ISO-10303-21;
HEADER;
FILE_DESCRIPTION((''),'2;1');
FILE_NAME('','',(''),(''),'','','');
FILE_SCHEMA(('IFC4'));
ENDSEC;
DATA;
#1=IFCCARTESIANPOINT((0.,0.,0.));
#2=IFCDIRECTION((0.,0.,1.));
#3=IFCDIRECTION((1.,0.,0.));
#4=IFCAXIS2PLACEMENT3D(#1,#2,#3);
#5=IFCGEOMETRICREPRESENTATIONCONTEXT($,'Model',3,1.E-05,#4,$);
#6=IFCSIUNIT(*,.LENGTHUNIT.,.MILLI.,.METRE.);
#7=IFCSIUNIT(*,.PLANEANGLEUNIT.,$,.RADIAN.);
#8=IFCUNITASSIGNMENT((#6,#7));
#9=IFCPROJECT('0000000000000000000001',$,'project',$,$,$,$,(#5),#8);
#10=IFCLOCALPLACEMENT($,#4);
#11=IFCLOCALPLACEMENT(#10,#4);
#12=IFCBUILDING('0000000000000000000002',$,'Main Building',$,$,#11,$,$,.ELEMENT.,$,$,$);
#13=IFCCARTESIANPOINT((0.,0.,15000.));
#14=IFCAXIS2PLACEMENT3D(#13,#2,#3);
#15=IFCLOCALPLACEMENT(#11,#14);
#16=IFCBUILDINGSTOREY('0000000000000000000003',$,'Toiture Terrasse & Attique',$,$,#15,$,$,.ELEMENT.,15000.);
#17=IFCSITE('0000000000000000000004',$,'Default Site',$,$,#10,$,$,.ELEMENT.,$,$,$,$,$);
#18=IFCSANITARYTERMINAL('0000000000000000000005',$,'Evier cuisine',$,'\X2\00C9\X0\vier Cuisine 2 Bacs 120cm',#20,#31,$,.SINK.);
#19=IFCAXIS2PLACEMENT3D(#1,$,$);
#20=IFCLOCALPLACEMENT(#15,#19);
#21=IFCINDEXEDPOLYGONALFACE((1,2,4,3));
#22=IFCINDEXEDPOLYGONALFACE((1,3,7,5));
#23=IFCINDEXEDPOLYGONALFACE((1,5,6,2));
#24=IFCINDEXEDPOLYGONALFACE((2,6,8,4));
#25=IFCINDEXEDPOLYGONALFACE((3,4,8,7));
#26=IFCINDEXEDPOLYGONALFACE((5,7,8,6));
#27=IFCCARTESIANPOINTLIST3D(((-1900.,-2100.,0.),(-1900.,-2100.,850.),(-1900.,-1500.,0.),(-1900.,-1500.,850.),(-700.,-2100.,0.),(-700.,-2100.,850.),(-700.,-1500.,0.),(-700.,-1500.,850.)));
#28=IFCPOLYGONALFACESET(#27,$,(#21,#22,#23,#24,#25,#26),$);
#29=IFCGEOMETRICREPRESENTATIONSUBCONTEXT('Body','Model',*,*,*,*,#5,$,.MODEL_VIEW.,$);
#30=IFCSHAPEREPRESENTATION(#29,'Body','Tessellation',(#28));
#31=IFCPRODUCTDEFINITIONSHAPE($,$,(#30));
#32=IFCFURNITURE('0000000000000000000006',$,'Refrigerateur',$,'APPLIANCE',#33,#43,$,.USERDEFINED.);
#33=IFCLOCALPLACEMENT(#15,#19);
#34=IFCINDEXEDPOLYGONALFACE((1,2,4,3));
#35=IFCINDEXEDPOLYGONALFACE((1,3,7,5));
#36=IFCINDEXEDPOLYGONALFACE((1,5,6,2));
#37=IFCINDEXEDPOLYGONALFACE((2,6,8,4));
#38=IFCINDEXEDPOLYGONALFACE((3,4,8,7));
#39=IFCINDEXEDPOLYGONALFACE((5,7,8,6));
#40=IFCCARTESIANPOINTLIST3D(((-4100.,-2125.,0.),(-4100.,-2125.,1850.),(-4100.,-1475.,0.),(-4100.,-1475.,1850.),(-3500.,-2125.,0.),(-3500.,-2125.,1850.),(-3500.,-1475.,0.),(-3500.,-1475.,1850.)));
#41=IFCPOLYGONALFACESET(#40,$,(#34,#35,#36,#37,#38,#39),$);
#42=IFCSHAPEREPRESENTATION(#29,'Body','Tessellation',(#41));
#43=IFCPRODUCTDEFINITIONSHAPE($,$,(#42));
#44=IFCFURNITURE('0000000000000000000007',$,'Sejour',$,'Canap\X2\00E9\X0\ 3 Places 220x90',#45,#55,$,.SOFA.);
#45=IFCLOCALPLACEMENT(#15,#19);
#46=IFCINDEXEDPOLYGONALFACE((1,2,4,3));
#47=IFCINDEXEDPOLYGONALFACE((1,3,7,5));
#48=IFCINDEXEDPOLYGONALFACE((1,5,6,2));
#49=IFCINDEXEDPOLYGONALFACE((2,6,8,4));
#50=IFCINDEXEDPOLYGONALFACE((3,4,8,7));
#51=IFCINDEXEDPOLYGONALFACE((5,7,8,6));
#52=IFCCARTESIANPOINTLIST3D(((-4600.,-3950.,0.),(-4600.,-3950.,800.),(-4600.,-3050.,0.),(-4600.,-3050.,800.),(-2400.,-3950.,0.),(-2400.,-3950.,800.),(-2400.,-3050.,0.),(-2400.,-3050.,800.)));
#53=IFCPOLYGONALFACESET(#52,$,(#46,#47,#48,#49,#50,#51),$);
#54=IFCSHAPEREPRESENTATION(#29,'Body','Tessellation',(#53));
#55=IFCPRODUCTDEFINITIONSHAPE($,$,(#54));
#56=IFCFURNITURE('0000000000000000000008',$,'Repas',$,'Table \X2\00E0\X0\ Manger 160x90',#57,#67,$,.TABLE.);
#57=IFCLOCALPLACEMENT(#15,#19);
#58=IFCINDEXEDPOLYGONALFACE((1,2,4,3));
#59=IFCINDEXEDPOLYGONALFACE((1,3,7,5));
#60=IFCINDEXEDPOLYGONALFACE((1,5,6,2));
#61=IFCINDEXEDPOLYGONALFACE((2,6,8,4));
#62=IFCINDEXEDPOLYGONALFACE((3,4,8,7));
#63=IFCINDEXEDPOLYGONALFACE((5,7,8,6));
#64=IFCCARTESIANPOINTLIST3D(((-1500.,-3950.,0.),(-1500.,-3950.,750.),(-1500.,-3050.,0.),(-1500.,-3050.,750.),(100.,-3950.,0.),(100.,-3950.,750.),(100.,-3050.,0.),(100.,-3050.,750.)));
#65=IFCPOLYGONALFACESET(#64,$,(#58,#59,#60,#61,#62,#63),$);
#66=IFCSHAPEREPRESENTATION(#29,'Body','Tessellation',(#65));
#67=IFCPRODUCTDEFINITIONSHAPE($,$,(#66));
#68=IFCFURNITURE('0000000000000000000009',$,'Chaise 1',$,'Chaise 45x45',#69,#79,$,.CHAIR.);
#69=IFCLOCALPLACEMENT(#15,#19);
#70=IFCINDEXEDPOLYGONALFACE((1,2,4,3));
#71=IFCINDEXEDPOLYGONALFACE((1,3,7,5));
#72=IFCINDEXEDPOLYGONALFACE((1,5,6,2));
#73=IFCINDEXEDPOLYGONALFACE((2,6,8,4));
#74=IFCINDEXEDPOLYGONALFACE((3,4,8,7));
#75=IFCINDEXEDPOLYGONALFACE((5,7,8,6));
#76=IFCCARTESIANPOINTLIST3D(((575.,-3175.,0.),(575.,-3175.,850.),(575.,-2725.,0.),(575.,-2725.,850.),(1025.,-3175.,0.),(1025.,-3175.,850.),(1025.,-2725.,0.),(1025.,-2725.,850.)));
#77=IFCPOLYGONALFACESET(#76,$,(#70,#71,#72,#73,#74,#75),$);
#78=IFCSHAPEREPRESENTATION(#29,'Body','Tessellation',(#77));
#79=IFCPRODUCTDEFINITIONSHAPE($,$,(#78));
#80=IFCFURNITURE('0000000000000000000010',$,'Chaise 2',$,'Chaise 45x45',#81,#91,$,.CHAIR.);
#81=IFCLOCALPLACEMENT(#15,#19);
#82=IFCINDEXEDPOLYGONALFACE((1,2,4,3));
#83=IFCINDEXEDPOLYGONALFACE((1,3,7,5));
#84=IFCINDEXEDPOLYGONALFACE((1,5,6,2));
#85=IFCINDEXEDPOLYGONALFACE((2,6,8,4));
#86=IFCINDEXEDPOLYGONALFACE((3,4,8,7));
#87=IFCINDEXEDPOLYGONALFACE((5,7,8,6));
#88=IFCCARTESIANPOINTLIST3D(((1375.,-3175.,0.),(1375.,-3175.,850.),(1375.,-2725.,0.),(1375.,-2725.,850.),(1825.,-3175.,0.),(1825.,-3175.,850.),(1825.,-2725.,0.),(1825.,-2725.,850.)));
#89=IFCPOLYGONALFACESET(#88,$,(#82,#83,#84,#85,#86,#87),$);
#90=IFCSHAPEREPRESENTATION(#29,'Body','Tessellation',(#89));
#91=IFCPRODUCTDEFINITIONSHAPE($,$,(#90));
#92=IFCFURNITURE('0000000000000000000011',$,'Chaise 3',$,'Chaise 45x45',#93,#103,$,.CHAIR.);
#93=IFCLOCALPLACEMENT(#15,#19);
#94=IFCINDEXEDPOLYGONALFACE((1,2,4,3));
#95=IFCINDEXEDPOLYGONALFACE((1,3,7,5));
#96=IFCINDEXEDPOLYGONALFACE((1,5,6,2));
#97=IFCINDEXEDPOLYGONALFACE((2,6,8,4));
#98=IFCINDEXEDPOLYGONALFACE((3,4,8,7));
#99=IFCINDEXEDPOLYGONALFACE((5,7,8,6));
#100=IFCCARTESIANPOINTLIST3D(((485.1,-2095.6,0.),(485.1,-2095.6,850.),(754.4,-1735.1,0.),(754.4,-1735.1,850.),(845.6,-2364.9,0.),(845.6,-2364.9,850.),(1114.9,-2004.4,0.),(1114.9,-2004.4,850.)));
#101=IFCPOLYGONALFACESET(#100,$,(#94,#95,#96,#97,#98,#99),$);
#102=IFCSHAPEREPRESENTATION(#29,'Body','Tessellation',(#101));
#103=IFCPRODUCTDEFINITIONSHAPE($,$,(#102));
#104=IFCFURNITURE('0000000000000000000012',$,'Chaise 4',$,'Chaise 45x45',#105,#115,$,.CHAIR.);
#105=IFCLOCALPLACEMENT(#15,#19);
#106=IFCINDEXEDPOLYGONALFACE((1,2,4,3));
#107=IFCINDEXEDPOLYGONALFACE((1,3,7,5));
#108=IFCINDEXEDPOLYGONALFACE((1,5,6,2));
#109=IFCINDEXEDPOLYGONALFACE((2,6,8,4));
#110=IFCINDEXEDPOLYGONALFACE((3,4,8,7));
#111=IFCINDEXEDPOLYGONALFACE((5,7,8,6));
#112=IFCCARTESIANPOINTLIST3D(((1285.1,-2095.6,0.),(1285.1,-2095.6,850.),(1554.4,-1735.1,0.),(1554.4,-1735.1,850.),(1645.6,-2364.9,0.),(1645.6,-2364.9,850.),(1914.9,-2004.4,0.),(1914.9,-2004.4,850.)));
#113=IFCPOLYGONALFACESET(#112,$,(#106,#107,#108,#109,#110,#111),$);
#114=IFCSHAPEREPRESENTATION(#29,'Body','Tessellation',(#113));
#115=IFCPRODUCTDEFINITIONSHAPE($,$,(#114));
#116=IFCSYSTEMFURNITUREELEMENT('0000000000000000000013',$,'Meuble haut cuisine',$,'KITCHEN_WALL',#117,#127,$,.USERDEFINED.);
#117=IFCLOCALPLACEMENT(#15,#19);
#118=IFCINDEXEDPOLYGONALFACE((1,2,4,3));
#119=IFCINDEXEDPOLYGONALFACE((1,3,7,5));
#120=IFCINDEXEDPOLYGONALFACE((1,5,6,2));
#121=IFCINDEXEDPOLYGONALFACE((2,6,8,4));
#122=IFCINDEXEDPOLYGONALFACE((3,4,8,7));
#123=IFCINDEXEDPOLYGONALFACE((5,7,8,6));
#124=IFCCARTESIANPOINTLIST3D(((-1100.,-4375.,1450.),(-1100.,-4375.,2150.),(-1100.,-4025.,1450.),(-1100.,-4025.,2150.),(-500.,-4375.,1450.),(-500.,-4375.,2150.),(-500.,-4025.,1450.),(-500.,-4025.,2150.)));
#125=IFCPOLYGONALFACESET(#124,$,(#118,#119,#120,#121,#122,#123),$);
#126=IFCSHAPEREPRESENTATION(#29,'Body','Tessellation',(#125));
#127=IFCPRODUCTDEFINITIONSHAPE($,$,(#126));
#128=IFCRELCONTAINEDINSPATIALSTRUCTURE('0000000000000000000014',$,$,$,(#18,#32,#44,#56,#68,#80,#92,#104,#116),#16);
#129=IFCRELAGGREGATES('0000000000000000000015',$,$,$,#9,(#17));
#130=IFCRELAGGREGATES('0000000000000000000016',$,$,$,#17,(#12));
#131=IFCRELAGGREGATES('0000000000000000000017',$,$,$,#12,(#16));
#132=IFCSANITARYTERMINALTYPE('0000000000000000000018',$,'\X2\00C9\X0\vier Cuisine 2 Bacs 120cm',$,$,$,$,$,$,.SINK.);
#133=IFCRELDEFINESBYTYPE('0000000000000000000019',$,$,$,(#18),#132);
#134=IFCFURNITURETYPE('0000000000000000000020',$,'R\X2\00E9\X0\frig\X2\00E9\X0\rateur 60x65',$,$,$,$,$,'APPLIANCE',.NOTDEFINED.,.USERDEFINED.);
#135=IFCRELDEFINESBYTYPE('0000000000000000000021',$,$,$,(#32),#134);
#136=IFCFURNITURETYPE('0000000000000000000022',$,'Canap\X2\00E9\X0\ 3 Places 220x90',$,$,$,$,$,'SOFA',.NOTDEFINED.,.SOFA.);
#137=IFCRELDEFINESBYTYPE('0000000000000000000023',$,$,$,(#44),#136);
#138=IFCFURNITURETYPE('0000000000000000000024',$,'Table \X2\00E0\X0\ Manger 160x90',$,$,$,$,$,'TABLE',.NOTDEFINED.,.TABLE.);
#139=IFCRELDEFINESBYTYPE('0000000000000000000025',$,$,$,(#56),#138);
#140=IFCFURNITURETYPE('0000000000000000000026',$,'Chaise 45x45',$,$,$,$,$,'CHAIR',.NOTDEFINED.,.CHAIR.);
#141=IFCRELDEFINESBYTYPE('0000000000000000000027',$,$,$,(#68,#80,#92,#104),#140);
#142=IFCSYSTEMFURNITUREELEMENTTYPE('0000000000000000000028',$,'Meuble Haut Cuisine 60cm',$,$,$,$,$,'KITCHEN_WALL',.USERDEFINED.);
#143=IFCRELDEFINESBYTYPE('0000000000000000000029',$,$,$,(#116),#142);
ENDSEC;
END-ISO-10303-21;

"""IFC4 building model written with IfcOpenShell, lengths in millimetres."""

from ifc_helpers import new_model, si_unit, frame, origin_with_axes, place, context, subcontext, project, spatial, polyline, outline, extrude, type_object, element, save


model = new_model("IFC4")

# Units and contexts
model_context = context("Model", 3, precision=1e-05, world=origin_with_axes())
body_context = subcontext(model_context, "Body", "Model", "MODEL_VIEW")
ifc_project = project(units=[si_unit("LENGTHUNIT", "METRE", prefix="MILLI"), si_unit("PLANEANGLEUNIT", "RADIAN")], contexts=[model_context])

# Site, building, storey
site_placement = place(None, origin_with_axes())
site = spatial("IfcSite", under=ifc_project, at=site_placement, Name="Default Site", CompositionType="ELEMENT")
building_placement = place(site_placement, origin_with_axes())
building = spatial("IfcBuilding", under=site, at=building_placement, Name="Main Building", CompositionType="ELEMENT")
storey_placement = place(building_placement, frame((0.0, 0.0, 15000.0), z_axis=(0.0, 0.0, 1.0), x_axis=(1.0, 0.0, 0.0)))
storey = spatial("IfcBuildingStorey", under=building, at=storey_placement, Name="Toiture Terrasse & Attique", CompositionType="ELEMENT", Elevation=15000.0)

# Sanitary terminal
sanitary_terminal_type = type_object("IfcSanitaryTerminalType", Name="Évier Cuisine 2 Bacs 120cm", PredefinedType="SINK")
sanitary_terminal_placement = place(storey_placement, frame((-1300.0, -1800.0, 0.0), z_axis=(0.0, 0.0, 1.0), x_axis=(1.0, 0.0, 0.0)))
element("IfcSanitaryTerminal", 1, at=sanitary_terminal_placement, inside=storey, type_object=sanitary_terminal_type, Name="Evier cuisine", ObjectType="Évier Cuisine 2 Bacs 120cm", PredefinedType="SINK", context=body_context, shape_type="SweptSolid", body=[
    extrude(outline(polyline([(-600.0, -300.0), (600.0, -300.0), (600.0, 300.0), (-600.0, 300.0), (-600.0, -300.0)])), origin_with_axes(), (0.0, 0.0, 1.0), 850.0),
])

# Furniture
furniture_type_1 = type_object("IfcFurnitureType", Name="Réfrigérateur 60x65", ElementType="APPLIANCE", AssemblyPlace="NOTDEFINED", PredefinedType="USERDEFINED")
furniture_1_placement = place(storey_placement, frame((-3800.0, -1800.0, 0.0), z_axis=(0.0, 0.0, 1.0), x_axis=(1.0, 0.0, 0.0)))
element("IfcFurniture", 2, at=furniture_1_placement, inside=storey, type_object=furniture_type_1, Name="Refrigerateur", ObjectType="APPLIANCE", PredefinedType="USERDEFINED", context=body_context, shape_type="SweptSolid", body=[
    extrude(outline(polyline([(-300.0, -325.0), (300.0, -325.0), (300.0, 325.0), (-300.0, 325.0), (-300.0, -325.0)])), origin_with_axes(), (0.0, 0.0, 1.0), 1850.0),
])
furniture_type_2 = type_object("IfcFurnitureType", Name="Canapé 3 Places 220x90", ElementType="SOFA", AssemblyPlace="NOTDEFINED", PredefinedType="SOFA")
furniture_2_placement = place(storey_placement, frame((-3500.0, -3500.0, 0.0), z_axis=(0.0, 0.0, 1.0), x_axis=(1.0, 0.0, 0.0)))
element("IfcFurniture", 3, at=furniture_2_placement, inside=storey, type_object=furniture_type_2, Name="Sejour", ObjectType="Canapé 3 Places 220x90", PredefinedType="SOFA", context=body_context, shape_type="SweptSolid", body=[
    extrude(outline(polyline([(-1100.0, -450.0), (1100.0, -450.0), (1100.0, 450.0), (-1100.0, 450.0), (-1100.0, -450.0)])), origin_with_axes(), (0.0, 0.0, 1.0), 800.0),
])
furniture_type_3 = type_object("IfcFurnitureType", Name="Table à Manger 160x90", ElementType="TABLE", AssemblyPlace="NOTDEFINED", PredefinedType="TABLE")
furniture_3_placement = place(storey_placement, frame((-700.0, -3500.0, 0.0), z_axis=(0.0, 0.0, 1.0), x_axis=(1.0, 0.0, 0.0)))
element("IfcFurniture", 4, at=furniture_3_placement, inside=storey, type_object=furniture_type_3, Name="Repas", ObjectType="Table à Manger 160x90", PredefinedType="TABLE", context=body_context, shape_type="SweptSolid", body=[
    extrude(outline(polyline([(-800.0, -450.0), (800.0, -450.0), (800.0, 450.0), (-800.0, 450.0), (-800.0, -450.0)])), origin_with_axes(), (0.0, 0.0, 1.0), 750.0),
])
furniture_type_4 = type_object("IfcFurnitureType", Name="Chaise 45x45", ElementType="CHAIR", AssemblyPlace="NOTDEFINED", PredefinedType="CHAIR")
for number, where, z_axis, x_axis, name in (
    (5, (800.0, -2950.0, 0.0), (0.0, 0.0, 1.0), (1.0, 0.0, 0.0), "Chaise 1"),
    (6, (1600.0, -2950.0, 0.0), (0.0, 0.0, 1.0), (1.0, 0.0, 0.0), "Chaise 2"),
    (7, (800.0, -2050.0, 0.0), (0.0, 0.0, 1.0), (-0.59846, -0.801153, 0.0), "Chaise 3"),
    (8, (1600.0, -2050.0, 0.0), (0.0, 0.0, 1.0), (-0.59846, -0.801153, 0.0), "Chaise 4"),
):
    element("IfcFurniture", number, at=place(storey_placement, frame(where, z_axis=z_axis, x_axis=x_axis)), inside=storey, type_object=furniture_type_4, Name=name, ObjectType="Chaise 45x45", PredefinedType="CHAIR", context=body_context, shape_type="SweptSolid", body=[
        extrude(outline(polyline([(-225.0, -225.0), (225.0, -225.0), (225.0, 225.0), (-225.0, 225.0), (-225.0, -225.0)])), origin_with_axes(), (0.0, 0.0, 1.0), 850.0),
    ])

# System furniture element
system_furniture_element_type = type_object("IfcSystemFurnitureElementType", Name="Meuble Haut Cuisine 60cm", ElementType="KITCHEN_WALL", PredefinedType="USERDEFINED")
system_furniture_element_placement = place(storey_placement, frame((-800.0, -4200.0, 1450.0), z_axis=(0.0, 0.0, 1.0), x_axis=(1.0, 0.0, 0.0)))
element("IfcSystemFurnitureElement", 9, at=system_furniture_element_placement, inside=storey, type_object=system_furniture_element_type, Name="Meuble haut cuisine", ObjectType="KITCHEN_WALL", PredefinedType="USERDEFINED", context=body_context, shape_type="SweptSolid", body=[
    extrude(outline(polyline([(-300.0, -175.0), (300.0, -175.0), (300.0, 175.0), (-300.0, 175.0), (-300.0, -175.0)])), origin_with_axes(), (0.0, 0.0, 1.0), 700.0),
])

save(model, "model.ifc")
